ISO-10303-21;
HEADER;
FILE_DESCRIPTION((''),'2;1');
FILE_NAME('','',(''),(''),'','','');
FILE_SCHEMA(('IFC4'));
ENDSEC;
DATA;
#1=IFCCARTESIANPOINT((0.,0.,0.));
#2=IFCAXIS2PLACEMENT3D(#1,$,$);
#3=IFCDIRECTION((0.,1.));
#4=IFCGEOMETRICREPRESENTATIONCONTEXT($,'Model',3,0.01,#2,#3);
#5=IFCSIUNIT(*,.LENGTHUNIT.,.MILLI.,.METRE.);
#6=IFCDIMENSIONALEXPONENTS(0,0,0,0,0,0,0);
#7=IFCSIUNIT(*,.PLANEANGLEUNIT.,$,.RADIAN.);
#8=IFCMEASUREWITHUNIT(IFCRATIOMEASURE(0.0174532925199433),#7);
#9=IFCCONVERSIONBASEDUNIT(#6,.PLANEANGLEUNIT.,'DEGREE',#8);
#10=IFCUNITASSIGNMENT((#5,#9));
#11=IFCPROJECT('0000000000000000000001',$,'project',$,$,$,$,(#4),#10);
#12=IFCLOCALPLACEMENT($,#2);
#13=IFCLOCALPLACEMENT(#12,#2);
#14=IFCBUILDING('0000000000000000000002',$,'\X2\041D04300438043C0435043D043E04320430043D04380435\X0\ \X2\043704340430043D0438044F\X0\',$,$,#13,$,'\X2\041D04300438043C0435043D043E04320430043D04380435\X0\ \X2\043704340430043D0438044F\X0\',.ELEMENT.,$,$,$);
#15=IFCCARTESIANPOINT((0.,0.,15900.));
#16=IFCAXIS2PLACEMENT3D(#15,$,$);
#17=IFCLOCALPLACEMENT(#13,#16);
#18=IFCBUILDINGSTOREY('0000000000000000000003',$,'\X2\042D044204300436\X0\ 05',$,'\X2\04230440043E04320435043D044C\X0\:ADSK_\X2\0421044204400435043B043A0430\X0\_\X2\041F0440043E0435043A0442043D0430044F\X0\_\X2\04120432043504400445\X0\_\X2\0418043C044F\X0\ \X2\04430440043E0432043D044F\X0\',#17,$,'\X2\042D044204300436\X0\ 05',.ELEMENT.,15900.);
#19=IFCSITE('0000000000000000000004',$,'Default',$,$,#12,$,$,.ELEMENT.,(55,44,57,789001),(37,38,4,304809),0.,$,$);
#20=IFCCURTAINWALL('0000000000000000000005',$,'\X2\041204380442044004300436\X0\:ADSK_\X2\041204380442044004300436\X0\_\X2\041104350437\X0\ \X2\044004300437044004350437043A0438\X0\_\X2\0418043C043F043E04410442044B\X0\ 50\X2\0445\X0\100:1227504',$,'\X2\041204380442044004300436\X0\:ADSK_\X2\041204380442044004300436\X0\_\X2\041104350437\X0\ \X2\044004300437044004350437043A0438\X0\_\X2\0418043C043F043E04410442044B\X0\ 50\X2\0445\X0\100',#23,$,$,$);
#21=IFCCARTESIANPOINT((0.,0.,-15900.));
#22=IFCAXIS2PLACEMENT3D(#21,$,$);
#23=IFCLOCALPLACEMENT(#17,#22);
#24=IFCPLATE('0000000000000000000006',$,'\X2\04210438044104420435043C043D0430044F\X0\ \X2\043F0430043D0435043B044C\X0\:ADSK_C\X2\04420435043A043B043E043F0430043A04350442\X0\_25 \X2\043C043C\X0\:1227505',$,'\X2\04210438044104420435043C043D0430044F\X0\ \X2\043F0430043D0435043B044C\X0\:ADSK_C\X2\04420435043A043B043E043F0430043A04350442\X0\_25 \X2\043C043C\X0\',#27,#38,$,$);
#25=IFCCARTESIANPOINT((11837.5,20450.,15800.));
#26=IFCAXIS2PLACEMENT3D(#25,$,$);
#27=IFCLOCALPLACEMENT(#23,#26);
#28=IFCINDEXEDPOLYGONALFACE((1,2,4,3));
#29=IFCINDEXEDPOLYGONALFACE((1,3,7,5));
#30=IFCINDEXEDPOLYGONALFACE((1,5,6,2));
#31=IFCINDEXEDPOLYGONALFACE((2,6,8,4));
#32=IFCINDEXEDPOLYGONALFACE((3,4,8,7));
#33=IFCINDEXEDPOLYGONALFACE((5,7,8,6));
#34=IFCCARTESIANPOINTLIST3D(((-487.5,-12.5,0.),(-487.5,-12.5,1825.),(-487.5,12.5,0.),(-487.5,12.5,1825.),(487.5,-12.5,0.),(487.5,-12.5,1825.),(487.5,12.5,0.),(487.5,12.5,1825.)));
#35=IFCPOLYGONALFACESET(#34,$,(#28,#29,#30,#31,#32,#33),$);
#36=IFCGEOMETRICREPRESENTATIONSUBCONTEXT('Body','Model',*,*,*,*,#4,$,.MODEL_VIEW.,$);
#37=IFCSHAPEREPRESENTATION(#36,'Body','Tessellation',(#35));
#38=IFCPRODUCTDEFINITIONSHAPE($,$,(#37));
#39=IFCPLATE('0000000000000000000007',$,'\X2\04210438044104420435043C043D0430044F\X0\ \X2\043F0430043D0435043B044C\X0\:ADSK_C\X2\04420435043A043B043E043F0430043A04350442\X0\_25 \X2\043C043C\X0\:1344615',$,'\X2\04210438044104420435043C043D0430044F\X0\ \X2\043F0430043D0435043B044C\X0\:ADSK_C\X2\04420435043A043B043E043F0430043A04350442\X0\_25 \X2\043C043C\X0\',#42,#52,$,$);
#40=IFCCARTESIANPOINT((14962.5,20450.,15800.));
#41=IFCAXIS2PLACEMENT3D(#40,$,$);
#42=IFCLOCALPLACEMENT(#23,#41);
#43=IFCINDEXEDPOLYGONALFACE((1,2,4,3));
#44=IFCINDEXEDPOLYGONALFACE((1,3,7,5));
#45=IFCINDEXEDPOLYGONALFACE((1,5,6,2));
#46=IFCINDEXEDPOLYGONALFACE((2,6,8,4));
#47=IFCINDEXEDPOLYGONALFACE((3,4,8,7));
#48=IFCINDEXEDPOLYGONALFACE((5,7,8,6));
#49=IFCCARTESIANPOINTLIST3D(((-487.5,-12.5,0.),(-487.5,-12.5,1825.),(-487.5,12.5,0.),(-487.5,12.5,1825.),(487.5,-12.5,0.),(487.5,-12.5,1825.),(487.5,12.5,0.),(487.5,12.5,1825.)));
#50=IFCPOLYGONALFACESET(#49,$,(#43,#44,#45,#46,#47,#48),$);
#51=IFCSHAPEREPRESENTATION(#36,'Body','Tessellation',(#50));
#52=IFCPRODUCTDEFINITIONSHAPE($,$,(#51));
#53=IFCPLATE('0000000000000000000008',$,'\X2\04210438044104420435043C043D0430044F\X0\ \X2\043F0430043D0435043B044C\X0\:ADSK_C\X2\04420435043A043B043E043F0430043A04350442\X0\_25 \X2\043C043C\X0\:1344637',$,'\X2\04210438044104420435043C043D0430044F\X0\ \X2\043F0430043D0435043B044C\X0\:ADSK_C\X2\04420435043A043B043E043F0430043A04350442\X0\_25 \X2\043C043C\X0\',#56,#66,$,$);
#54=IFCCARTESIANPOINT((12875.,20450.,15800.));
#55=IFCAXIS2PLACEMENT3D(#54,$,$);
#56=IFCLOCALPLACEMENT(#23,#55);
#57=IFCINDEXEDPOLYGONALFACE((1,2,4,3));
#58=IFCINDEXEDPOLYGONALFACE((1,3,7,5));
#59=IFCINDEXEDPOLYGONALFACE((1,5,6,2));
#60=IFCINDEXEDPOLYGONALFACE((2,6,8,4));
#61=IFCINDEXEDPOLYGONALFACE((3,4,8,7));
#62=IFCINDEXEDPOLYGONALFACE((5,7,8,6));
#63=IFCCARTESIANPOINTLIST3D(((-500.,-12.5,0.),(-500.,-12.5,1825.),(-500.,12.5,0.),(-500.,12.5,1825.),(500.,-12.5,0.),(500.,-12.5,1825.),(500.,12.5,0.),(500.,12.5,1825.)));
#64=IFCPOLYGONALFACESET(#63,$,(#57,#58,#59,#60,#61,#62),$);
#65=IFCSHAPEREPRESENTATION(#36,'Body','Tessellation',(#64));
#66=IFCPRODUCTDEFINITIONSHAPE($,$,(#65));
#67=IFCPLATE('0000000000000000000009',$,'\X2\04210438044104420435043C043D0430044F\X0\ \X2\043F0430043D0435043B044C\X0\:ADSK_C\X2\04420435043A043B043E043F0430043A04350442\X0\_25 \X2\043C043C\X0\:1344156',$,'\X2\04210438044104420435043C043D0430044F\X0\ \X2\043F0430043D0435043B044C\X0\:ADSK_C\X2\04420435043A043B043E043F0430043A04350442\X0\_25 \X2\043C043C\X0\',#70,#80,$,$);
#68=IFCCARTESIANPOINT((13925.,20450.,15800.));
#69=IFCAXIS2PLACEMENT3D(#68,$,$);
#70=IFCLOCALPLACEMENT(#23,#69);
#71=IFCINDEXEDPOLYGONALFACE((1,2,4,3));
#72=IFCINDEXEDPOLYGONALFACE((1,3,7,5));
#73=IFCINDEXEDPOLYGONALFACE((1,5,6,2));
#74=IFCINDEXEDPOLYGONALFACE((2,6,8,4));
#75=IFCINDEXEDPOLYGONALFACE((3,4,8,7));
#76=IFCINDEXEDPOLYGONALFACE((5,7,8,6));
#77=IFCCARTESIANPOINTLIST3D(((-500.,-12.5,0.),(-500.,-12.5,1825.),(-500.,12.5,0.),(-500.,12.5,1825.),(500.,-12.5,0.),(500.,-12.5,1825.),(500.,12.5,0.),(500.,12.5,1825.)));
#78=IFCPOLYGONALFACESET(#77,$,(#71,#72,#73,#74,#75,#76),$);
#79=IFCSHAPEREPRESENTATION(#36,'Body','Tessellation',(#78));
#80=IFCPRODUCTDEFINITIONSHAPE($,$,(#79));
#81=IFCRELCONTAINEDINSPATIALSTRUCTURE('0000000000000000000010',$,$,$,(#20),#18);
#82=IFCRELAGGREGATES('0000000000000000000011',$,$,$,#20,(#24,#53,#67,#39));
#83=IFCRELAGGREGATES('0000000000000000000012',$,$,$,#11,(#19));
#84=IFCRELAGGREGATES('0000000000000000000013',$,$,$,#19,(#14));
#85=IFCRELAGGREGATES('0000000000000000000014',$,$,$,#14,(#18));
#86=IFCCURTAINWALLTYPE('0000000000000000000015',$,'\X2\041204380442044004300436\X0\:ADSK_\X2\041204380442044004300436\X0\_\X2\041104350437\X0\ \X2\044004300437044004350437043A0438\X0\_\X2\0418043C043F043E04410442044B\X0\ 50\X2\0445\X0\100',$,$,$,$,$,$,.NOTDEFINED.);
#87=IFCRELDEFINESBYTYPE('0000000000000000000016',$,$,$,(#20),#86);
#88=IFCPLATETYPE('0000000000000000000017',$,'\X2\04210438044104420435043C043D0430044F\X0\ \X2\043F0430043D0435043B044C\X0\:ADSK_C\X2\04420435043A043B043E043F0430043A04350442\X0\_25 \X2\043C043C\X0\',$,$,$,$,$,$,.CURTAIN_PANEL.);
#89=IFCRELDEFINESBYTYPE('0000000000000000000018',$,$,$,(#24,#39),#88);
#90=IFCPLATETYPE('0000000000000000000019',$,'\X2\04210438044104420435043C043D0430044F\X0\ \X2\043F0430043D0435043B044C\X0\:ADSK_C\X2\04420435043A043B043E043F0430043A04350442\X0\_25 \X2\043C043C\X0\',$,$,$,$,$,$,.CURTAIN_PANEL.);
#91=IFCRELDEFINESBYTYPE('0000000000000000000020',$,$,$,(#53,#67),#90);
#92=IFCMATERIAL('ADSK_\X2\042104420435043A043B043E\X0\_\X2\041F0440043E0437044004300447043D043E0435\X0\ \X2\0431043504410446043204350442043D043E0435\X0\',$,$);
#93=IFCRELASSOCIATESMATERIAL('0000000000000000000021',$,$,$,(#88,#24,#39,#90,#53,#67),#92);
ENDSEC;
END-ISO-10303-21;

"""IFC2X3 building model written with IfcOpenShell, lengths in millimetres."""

from ifc_helpers import new_model, entity, si_unit, converted_unit, direction, frame, origin, origin_2d_with_axis, place, context, subcontext, project, spatial, rectangle, extrude, source, transform, mapped, material, type_object, type_shapes, element, aggregate, save


model = new_model("IFC2X3")

# Units and contexts
model_context = context("Model", 3, precision=0.01, world=origin(), true_north=direction((0.0, 1.0)))
body_context = subcontext(model_context, "Body", "Model", "MODEL_VIEW")
ifc_project = project(units=[si_unit("LENGTHUNIT", "METRE", prefix="MILLI"), converted_unit("PLANEANGLEUNIT", "DEGREE", entity("IfcRatioMeasure", 0.0174532925199433), si_unit("PLANEANGLEUNIT", "RADIAN"), dimensions=[0, 0, 0, 0, 0, 0, 0])], contexts=[model_context])

# Site, building, storey
site_placement = place(None, origin())
site = spatial("IfcSite", under=ifc_project, at=site_placement, Name="Default", CompositionType="ELEMENT", RefLatitude=(55, 44, 57, 789001), RefLongitude=(37, 38, 4, 304809), RefElevation=0.0)
building_placement = place(site_placement, origin())
building = spatial("IfcBuilding", under=site, at=building_placement, Name="Наименование здания", LongName="Наименование здания", CompositionType="ELEMENT")
storey_placement = place(building_placement, frame((0.0, 0.0, 15900.0)))
storey = spatial("IfcBuildingStorey", under=building, at=storey_placement, Name="Этаж 05", ObjectType="Уровень:ADSK_Стрелка_Проектная_Вверх_Имя уровня", LongName="Этаж 05", CompositionType="ELEMENT", Elevation=15900.0)

# Curtain wall, plates
curtain_wall_type = type_object("IfcCurtainWallType", Name="Витраж:ADSK_Витраж_Без разрезки_Импосты 50х100", PredefinedType="NOTDEFINED")
curtain_wall_placement = place(storey_placement, frame((0.0, 0.0, -15900.0)))
curtain_wall = element("IfcCurtainWall", 1, at=curtain_wall_placement, inside=storey, type_object=curtain_wall_type, Name="Витраж:ADSK_Витраж_Без разрезки_Импосты 50х100:1227504", ObjectType="Витраж:ADSK_Витраж_Без разрезки_Импосты 50х100")
ifc_material_1 = material(Name="ADSK_Стекло_Прозрачное бесцветное")
plate_type_1 = type_object("IfcPlateType", Name="Системная панель:ADSK_Cтеклопакет_25 мм", PredefinedType="CURTAIN_PANEL", material=ifc_material_1)
shared_shape_1 = source(origin(), body_context, "Body", "SweptSolid", [
    extrude(rectangle(XDim=25.0, YDim=975.0, at=origin_2d_with_axis()), frame((0.0, 0.0, 0.0), z_axis=(0.0, 0.0, 1.0), x_axis=(0.0, 1.0, 0.0)), (0.0, 0.0, 1.0), 1825.0),
])
type_shapes(plate_type_1, [shared_shape_1])
plate_1_placement = place(curtain_wall_placement, frame((11837.5, 20450.0, 15800.0)))
plate_1 = element("IfcPlate", 2, at=plate_1_placement, type_object=plate_type_1, material=ifc_material_1, Name="Системная панель:ADSK_Cтеклопакет_25 мм:1227505", ObjectType="Системная панель:ADSK_Cтеклопакет_25 мм", context=body_context, shape_type="MappedRepresentation", body=[
    mapped(shared_shape_1, transform((0.0, 0.0, 0.0), scale=1.0)),
])
plate_2_placement = place(curtain_wall_placement, frame((14962.5, 20450.0, 15800.0)))
plate_2 = element("IfcPlate", 3, at=plate_2_placement, type_object=plate_type_1, material=ifc_material_1, Name="Системная панель:ADSK_Cтеклопакет_25 мм:1344615", ObjectType="Системная панель:ADSK_Cтеклопакет_25 мм", context=body_context, shape_type="MappedRepresentation", body=[
    mapped(shared_shape_1, transform((0.0, 0.0, 0.0), scale=1.0)),
])
plate_type_2 = type_object("IfcPlateType", Name="Системная панель:ADSK_Cтеклопакет_25 мм", PredefinedType="CURTAIN_PANEL", material=ifc_material_1)
shared_shape_2 = source(origin(), body_context, "Body", "SweptSolid", [
    extrude(rectangle(XDim=25.0, YDim=1000.0, at=origin_2d_with_axis()), frame((0.0, 0.0, 0.0), z_axis=(0.0, 0.0, 1.0), x_axis=(0.0, 1.0, 0.0)), (0.0, 0.0, 1.0), 1825.0),
])
type_shapes(plate_type_2, [shared_shape_2])
plate_3_placement = place(curtain_wall_placement, frame((12875.0, 20450.0, 15800.0)))
plate_3 = element("IfcPlate", 4, at=plate_3_placement, type_object=plate_type_2, material=ifc_material_1, Name="Системная панель:ADSK_Cтеклопакет_25 мм:1344637", ObjectType="Системная панель:ADSK_Cтеклопакет_25 мм", context=body_context, shape_type="MappedRepresentation", body=[
    mapped(shared_shape_2, transform((0.0, 0.0, 0.0), scale=1.0)),
])
plate_4_placement = place(curtain_wall_placement, frame((13925.0, 20450.0, 15800.0)))
plate_4 = element("IfcPlate", 5, at=plate_4_placement, type_object=plate_type_2, material=ifc_material_1, Name="Системная панель:ADSK_Cтеклопакет_25 мм:1344156", ObjectType="Системная панель:ADSK_Cтеклопакет_25 мм", context=body_context, shape_type="MappedRepresentation", body=[
    mapped(shared_shape_2, transform((0.0, 0.0, 0.0), scale=1.0)),
])
aggregate(curtain_wall, [plate_1, plate_3, plate_4, plate_2])

save(model, "model.ifc")
